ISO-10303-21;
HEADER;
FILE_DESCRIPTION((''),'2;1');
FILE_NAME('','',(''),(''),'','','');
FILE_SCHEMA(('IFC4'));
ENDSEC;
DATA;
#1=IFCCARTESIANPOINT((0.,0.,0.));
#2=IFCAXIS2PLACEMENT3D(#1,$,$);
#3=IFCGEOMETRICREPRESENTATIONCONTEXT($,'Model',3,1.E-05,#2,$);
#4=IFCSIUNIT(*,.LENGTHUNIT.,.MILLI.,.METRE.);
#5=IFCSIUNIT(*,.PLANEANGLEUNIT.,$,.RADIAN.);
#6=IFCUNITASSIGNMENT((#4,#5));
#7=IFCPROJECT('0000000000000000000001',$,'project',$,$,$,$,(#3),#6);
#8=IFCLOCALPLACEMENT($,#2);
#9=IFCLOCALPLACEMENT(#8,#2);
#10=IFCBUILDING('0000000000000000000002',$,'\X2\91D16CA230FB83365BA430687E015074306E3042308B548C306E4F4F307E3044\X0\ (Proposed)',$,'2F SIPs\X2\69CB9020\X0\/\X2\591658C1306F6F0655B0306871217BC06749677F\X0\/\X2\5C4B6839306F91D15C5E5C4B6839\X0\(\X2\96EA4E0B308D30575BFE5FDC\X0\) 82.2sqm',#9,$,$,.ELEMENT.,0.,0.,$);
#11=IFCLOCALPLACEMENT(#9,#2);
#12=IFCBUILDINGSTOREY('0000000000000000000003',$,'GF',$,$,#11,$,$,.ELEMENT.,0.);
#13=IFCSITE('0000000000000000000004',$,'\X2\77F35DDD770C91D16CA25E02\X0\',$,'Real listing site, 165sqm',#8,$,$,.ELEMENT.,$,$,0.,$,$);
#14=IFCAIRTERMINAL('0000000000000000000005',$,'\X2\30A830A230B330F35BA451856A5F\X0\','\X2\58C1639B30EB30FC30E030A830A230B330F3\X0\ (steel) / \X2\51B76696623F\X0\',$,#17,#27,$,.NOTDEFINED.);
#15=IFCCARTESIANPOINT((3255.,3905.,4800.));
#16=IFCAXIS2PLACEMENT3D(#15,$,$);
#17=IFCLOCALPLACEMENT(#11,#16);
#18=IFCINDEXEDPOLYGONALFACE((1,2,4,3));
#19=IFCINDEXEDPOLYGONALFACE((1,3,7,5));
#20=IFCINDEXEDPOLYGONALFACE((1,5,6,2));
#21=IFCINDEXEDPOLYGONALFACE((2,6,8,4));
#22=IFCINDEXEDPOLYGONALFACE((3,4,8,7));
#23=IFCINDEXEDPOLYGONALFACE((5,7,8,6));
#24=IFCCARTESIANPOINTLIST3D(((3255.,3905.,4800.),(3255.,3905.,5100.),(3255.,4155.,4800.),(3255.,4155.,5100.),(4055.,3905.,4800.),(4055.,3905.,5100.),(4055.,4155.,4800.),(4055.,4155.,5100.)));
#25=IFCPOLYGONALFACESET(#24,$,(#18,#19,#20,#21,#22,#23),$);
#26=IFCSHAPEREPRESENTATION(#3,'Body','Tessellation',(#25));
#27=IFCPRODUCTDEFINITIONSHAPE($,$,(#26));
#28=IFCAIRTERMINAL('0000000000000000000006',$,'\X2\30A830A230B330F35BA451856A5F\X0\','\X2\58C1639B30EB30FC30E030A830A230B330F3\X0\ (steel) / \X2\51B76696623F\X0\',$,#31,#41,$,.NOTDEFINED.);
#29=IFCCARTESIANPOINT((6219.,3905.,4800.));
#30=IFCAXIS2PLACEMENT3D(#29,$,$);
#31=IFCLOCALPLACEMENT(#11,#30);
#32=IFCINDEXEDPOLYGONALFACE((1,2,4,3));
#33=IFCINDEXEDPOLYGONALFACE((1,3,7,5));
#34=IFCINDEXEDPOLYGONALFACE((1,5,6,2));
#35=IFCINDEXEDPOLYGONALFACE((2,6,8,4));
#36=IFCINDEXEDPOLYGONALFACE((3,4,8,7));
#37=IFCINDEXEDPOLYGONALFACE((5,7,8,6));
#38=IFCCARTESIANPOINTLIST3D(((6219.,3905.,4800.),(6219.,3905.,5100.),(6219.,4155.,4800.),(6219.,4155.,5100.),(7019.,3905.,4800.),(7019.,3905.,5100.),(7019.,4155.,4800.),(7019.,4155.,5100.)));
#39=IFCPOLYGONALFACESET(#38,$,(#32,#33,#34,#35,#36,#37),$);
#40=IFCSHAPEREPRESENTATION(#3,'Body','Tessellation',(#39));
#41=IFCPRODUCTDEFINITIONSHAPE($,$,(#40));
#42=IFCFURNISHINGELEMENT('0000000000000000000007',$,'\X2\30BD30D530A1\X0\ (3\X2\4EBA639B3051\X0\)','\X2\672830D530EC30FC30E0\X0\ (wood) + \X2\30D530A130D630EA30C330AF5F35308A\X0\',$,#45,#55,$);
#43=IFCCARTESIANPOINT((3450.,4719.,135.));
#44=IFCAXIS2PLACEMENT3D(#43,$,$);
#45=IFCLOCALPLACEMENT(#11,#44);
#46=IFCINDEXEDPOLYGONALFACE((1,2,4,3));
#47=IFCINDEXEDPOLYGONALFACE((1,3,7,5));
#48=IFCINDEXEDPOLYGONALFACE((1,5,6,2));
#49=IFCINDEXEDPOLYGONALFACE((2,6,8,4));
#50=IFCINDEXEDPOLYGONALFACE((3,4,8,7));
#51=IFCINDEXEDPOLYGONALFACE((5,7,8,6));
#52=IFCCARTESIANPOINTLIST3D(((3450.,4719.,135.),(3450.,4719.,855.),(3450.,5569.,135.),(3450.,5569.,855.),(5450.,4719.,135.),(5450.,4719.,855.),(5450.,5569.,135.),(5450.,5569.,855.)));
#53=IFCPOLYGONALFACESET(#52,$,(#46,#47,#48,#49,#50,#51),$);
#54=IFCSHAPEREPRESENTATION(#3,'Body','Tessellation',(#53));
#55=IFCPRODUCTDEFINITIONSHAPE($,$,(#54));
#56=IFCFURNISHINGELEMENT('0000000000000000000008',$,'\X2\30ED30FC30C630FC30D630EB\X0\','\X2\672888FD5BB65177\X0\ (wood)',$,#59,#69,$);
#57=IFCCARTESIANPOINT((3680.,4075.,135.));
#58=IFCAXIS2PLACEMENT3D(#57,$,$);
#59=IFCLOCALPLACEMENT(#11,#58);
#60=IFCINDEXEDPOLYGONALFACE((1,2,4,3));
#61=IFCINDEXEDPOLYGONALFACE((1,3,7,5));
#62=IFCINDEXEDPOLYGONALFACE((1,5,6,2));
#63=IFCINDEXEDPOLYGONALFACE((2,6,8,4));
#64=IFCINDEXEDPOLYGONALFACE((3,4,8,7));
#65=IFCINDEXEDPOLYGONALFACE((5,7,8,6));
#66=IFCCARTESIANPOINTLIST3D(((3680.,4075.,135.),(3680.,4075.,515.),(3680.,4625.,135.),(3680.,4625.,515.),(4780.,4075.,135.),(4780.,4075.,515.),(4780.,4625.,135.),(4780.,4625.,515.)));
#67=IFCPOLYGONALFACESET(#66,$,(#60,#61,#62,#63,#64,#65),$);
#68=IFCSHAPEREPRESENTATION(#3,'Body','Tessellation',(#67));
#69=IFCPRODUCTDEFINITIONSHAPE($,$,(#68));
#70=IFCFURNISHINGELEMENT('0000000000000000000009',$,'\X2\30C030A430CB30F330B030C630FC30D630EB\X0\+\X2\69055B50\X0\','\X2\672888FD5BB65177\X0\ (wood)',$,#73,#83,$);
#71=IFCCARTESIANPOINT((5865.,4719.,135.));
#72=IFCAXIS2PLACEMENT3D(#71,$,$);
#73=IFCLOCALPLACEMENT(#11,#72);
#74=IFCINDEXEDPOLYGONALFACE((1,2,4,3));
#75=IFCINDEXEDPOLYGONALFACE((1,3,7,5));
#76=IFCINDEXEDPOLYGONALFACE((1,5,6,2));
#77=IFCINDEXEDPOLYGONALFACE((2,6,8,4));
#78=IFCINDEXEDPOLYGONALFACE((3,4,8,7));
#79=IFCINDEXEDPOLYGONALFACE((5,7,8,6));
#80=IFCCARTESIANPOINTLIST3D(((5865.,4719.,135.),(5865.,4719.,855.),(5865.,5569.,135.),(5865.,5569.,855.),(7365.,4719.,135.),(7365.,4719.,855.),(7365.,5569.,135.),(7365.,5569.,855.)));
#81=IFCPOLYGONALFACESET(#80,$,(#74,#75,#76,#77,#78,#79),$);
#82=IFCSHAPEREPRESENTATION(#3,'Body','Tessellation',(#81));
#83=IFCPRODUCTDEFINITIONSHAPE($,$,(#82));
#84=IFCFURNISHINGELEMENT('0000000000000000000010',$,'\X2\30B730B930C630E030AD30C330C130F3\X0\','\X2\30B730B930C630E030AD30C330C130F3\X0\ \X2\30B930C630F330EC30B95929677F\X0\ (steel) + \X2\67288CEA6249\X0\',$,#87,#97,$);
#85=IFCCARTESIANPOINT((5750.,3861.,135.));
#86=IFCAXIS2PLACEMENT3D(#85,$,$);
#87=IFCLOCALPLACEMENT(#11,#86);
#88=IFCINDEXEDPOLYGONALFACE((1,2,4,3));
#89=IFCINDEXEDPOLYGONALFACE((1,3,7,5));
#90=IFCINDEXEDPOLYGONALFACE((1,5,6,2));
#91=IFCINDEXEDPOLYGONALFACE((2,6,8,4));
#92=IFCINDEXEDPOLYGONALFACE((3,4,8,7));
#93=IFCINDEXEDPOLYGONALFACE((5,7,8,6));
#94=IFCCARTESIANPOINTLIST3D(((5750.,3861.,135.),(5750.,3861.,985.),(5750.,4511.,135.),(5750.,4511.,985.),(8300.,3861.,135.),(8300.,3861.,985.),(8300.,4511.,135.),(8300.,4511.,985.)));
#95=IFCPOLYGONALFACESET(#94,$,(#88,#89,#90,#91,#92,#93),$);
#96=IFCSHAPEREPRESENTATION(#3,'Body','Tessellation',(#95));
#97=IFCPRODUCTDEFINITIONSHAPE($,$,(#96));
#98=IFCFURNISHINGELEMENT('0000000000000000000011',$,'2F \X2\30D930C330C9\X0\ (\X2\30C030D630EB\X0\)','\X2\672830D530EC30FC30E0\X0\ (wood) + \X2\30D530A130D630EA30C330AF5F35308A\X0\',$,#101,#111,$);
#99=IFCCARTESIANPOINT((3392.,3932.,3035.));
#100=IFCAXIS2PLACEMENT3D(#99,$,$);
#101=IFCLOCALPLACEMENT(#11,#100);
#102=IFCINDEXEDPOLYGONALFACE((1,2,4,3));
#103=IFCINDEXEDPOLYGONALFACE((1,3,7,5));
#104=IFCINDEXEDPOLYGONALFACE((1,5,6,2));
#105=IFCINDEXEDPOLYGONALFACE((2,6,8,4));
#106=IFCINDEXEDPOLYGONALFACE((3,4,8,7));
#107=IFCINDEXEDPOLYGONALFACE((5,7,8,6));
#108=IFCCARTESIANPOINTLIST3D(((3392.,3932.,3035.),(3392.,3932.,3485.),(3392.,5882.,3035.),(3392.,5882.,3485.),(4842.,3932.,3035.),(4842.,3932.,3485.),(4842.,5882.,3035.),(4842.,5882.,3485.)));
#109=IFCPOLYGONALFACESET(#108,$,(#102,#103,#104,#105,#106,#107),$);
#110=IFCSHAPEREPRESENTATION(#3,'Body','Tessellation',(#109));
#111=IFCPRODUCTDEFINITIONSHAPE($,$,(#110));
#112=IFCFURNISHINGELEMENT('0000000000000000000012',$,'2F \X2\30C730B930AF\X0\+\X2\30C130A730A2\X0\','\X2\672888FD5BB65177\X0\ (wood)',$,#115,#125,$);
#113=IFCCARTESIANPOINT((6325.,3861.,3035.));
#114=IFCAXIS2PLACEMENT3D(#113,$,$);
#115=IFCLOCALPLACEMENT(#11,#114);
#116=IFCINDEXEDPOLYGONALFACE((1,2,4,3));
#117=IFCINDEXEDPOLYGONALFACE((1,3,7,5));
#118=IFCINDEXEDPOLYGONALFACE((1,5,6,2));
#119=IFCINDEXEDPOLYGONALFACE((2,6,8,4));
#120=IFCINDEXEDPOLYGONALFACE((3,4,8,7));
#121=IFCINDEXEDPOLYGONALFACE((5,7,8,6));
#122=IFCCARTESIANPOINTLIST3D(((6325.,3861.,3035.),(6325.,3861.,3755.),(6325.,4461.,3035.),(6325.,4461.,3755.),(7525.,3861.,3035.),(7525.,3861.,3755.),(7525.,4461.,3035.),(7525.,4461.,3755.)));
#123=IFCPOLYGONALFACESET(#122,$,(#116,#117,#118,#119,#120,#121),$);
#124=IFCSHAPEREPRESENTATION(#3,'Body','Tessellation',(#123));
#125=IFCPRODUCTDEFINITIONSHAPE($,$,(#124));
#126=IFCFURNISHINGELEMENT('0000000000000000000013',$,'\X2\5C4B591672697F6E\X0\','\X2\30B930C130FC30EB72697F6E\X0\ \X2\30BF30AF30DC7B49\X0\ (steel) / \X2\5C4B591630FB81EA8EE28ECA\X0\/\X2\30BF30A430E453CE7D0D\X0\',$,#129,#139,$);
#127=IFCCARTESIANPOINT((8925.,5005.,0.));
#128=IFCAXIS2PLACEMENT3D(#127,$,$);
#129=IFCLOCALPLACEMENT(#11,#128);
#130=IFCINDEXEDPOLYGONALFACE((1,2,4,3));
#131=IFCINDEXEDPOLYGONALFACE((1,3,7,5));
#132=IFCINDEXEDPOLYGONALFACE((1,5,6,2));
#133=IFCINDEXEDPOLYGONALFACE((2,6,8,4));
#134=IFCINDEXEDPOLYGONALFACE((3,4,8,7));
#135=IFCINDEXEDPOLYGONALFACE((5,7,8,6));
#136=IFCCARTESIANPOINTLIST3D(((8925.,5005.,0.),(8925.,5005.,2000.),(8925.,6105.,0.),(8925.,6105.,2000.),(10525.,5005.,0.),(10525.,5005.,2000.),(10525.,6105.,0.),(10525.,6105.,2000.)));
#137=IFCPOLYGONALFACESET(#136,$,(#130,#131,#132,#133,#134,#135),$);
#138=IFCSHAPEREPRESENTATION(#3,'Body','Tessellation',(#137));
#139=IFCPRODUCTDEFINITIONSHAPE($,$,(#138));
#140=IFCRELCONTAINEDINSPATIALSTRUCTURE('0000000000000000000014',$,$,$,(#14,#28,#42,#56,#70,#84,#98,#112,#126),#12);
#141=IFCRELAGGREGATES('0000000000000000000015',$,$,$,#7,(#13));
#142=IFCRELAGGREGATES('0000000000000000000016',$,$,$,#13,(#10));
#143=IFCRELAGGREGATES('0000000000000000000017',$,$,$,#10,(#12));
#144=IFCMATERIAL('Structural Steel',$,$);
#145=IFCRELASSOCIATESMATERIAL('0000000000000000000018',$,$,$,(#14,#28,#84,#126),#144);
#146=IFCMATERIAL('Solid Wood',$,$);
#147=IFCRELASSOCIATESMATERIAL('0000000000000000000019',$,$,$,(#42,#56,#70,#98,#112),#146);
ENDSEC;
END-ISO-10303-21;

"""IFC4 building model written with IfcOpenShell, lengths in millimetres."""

from ifc_helpers import new_model, si_unit, frame, frame_2d, origin, place, context, project, spatial, rectangle, extrude, material, element, save


model = new_model("IFC4")

# Units and contexts
model_context = context("Model", 3, precision=1e-05, world=origin())
ifc_project = project(units=[si_unit("LENGTHUNIT", "METRE", prefix="MILLI"), si_unit("PLANEANGLEUNIT", "RADIAN")], contexts=[model_context])

# Site, building, storey
site_placement = place(None, origin())
site = spatial("IfcSite", under=ifc_project, at=site_placement, Name="石川県金沢市", ObjectType="Real listing site, 165sqm", CompositionType="ELEMENT", RefElevation=0.0)
building_placement = place(site_placement, origin())
building = spatial("IfcBuilding", under=site, at=building_placement, Name="金沢・茶室と縁側のある和の住まい (Proposed)", ObjectType="2F SIPs構造/外壁は漆喰と無節杉板/屋根は金属屋根(雪下ろし対応) 82.2sqm", CompositionType="ELEMENT", ElevationOfRefHeight=0.0, ElevationOfTerrain=0.0)
storey_placement = place(building_placement, origin())
storey = spatial("IfcBuildingStorey", under=building, at=storey_placement, Name="GF", CompositionType="ELEMENT", Elevation=0.0)

# Shared definitions
ifc_material_1 = material(Name="Solid Wood")

# Shared definitions
ifc_material_2 = material(Name="Structural Steel")

# Air terminals
air_terminal_1_placement = place(storey_placement, frame((3255.0, 3905.0, 4800.0)))
element("IfcAirTerminal", 1, at=air_terminal_1_placement, inside=storey, material=ifc_material_2, Name="エアコン室内機", Description="壁掛ルームエアコン (steel) / 冷暖房", PredefinedType="NOTDEFINED", context=model_context, shape_type="SweptSolid", body=[
    extrude(rectangle(XDim=800.0, YDim=250.0, at=frame_2d((400.0, 125.0))), frame((3255.0, 3905.0, 4800.0)), (0.0, 0.0, 1.0), 300.0),
])
air_terminal_2_placement = place(storey_placement, frame((6219.0, 3905.0, 4800.0)))
element("IfcAirTerminal", 2, at=air_terminal_2_placement, inside=storey, material=ifc_material_2, Name="エアコン室内機", Description="壁掛ルームエアコン (steel) / 冷暖房", PredefinedType="NOTDEFINED", context=model_context, shape_type="SweptSolid", body=[
    extrude(rectangle(XDim=800.0, YDim=250.0, at=frame_2d((400.0, 125.0))), frame((6219.0, 3905.0, 4800.0)), (0.0, 0.0, 1.0), 300.0),
])

# Furnishing elements
furnishing_1_placement = place(storey_placement, frame((3450.0, 4719.0, 135.0)))
element("IfcFurnishingElement", 3, at=furnishing_1_placement, inside=storey, material=ifc_material_1, Name="ソファ (3人掛け)", Description="木フレーム (wood) + ファブリック張り", context=model_context, shape_type="SweptSolid", body=[
    extrude(rectangle(XDim=2000.0, YDim=850.0, at=frame_2d((1000.0, 425.0))), frame((3450.0, 4719.0, 135.0)), (0.0, 0.0, 1.0), 720.0),
])
furnishing_2_placement = place(storey_placement, frame((3680.0, 4075.0, 135.0)))
element("IfcFurnishingElement", 4, at=furnishing_2_placement, inside=storey, material=ifc_material_1, Name="ローテーブル", Description="木製家具 (wood)", context=model_context, shape_type="SweptSolid", body=[
    extrude(rectangle(XDim=1100.0, YDim=550.0, at=frame_2d((550.0, 275.0))), frame((3680.0, 4075.0, 135.0)), (0.0, 0.0, 1.0), 380.0),
])
furnishing_3_placement = place(storey_placement, frame((5865.0, 4719.0, 135.0)))
element("IfcFurnishingElement", 5, at=furnishing_3_placement, inside=storey, material=ifc_material_1, Name="ダイニングテーブル+椅子", Description="木製家具 (wood)", context=model_context, shape_type="SweptSolid", body=[
    extrude(rectangle(XDim=1500.0, YDim=850.0, at=frame_2d((750.0, 425.0))), frame((5865.0, 4719.0, 135.0)), (0.0, 0.0, 1.0), 720.0),
])
furnishing_4_placement = place(storey_placement, frame((5750.0, 3861.0, 135.0)))
element("IfcFurnishingElement", 6, at=furnishing_4_placement, inside=storey, material=ifc_material_2, Name="システムキッチン", Description="システムキッチン ステンレス天板 (steel) + 木質扉", context=model_context, shape_type="SweptSolid", body=[
    extrude(rectangle(XDim=2550.0, YDim=650.0, at=frame_2d((1275.0, 325.0))), frame((5750.0, 3861.0, 135.0)), (0.0, 0.0, 1.0), 850.0),
])
furnishing_5_placement = place(storey_placement, frame((3392.0, 3932.0, 3035.0)))
element("IfcFurnishingElement", 7, at=furnishing_5_placement, inside=storey, material=ifc_material_1, Name="2F ベッド (ダブル)", Description="木フレーム (wood) + ファブリック張り", context=model_context, shape_type="SweptSolid", body=[
    extrude(rectangle(XDim=1450.0, YDim=1950.0, at=frame_2d((725.0, 975.0))), frame((3392.0, 3932.0, 3035.0)), (0.0, 0.0, 1.0), 450.0),
])
furnishing_6_placement = place(storey_placement, frame((6325.0, 3861.0, 3035.0)))
element("IfcFurnishingElement", 8, at=furnishing_6_placement, inside=storey, material=ifc_material_1, Name="2F デスク+チェア", Description="木製家具 (wood)", context=model_context, shape_type="SweptSolid", body=[
    extrude(rectangle(XDim=1200.0, YDim=600.0, at=frame_2d((600.0, 300.0))), frame((6325.0, 3861.0, 3035.0)), (0.0, 0.0, 1.0), 720.0),
])
furnishing_7_placement = place(storey_placement, frame((8925.0, 5005.0, 0.0)))
element("IfcFurnishingElement", 9, at=furnishing_7_placement, inside=storey, material=ifc_material_2, Name="屋外物置", Description="スチール物置 タクボ等 (steel) / 屋外・自転車/タイヤ収納", context=model_context, shape_type="SweptSolid", body=[
    extrude(rectangle(XDim=1600.0, YDim=1100.0, at=frame_2d((800.0, 550.0))), frame((8925.0, 5005.0, 0.0)), (0.0, 0.0, 1.0), 2000.0),
])

save(model, "model.ifc")
